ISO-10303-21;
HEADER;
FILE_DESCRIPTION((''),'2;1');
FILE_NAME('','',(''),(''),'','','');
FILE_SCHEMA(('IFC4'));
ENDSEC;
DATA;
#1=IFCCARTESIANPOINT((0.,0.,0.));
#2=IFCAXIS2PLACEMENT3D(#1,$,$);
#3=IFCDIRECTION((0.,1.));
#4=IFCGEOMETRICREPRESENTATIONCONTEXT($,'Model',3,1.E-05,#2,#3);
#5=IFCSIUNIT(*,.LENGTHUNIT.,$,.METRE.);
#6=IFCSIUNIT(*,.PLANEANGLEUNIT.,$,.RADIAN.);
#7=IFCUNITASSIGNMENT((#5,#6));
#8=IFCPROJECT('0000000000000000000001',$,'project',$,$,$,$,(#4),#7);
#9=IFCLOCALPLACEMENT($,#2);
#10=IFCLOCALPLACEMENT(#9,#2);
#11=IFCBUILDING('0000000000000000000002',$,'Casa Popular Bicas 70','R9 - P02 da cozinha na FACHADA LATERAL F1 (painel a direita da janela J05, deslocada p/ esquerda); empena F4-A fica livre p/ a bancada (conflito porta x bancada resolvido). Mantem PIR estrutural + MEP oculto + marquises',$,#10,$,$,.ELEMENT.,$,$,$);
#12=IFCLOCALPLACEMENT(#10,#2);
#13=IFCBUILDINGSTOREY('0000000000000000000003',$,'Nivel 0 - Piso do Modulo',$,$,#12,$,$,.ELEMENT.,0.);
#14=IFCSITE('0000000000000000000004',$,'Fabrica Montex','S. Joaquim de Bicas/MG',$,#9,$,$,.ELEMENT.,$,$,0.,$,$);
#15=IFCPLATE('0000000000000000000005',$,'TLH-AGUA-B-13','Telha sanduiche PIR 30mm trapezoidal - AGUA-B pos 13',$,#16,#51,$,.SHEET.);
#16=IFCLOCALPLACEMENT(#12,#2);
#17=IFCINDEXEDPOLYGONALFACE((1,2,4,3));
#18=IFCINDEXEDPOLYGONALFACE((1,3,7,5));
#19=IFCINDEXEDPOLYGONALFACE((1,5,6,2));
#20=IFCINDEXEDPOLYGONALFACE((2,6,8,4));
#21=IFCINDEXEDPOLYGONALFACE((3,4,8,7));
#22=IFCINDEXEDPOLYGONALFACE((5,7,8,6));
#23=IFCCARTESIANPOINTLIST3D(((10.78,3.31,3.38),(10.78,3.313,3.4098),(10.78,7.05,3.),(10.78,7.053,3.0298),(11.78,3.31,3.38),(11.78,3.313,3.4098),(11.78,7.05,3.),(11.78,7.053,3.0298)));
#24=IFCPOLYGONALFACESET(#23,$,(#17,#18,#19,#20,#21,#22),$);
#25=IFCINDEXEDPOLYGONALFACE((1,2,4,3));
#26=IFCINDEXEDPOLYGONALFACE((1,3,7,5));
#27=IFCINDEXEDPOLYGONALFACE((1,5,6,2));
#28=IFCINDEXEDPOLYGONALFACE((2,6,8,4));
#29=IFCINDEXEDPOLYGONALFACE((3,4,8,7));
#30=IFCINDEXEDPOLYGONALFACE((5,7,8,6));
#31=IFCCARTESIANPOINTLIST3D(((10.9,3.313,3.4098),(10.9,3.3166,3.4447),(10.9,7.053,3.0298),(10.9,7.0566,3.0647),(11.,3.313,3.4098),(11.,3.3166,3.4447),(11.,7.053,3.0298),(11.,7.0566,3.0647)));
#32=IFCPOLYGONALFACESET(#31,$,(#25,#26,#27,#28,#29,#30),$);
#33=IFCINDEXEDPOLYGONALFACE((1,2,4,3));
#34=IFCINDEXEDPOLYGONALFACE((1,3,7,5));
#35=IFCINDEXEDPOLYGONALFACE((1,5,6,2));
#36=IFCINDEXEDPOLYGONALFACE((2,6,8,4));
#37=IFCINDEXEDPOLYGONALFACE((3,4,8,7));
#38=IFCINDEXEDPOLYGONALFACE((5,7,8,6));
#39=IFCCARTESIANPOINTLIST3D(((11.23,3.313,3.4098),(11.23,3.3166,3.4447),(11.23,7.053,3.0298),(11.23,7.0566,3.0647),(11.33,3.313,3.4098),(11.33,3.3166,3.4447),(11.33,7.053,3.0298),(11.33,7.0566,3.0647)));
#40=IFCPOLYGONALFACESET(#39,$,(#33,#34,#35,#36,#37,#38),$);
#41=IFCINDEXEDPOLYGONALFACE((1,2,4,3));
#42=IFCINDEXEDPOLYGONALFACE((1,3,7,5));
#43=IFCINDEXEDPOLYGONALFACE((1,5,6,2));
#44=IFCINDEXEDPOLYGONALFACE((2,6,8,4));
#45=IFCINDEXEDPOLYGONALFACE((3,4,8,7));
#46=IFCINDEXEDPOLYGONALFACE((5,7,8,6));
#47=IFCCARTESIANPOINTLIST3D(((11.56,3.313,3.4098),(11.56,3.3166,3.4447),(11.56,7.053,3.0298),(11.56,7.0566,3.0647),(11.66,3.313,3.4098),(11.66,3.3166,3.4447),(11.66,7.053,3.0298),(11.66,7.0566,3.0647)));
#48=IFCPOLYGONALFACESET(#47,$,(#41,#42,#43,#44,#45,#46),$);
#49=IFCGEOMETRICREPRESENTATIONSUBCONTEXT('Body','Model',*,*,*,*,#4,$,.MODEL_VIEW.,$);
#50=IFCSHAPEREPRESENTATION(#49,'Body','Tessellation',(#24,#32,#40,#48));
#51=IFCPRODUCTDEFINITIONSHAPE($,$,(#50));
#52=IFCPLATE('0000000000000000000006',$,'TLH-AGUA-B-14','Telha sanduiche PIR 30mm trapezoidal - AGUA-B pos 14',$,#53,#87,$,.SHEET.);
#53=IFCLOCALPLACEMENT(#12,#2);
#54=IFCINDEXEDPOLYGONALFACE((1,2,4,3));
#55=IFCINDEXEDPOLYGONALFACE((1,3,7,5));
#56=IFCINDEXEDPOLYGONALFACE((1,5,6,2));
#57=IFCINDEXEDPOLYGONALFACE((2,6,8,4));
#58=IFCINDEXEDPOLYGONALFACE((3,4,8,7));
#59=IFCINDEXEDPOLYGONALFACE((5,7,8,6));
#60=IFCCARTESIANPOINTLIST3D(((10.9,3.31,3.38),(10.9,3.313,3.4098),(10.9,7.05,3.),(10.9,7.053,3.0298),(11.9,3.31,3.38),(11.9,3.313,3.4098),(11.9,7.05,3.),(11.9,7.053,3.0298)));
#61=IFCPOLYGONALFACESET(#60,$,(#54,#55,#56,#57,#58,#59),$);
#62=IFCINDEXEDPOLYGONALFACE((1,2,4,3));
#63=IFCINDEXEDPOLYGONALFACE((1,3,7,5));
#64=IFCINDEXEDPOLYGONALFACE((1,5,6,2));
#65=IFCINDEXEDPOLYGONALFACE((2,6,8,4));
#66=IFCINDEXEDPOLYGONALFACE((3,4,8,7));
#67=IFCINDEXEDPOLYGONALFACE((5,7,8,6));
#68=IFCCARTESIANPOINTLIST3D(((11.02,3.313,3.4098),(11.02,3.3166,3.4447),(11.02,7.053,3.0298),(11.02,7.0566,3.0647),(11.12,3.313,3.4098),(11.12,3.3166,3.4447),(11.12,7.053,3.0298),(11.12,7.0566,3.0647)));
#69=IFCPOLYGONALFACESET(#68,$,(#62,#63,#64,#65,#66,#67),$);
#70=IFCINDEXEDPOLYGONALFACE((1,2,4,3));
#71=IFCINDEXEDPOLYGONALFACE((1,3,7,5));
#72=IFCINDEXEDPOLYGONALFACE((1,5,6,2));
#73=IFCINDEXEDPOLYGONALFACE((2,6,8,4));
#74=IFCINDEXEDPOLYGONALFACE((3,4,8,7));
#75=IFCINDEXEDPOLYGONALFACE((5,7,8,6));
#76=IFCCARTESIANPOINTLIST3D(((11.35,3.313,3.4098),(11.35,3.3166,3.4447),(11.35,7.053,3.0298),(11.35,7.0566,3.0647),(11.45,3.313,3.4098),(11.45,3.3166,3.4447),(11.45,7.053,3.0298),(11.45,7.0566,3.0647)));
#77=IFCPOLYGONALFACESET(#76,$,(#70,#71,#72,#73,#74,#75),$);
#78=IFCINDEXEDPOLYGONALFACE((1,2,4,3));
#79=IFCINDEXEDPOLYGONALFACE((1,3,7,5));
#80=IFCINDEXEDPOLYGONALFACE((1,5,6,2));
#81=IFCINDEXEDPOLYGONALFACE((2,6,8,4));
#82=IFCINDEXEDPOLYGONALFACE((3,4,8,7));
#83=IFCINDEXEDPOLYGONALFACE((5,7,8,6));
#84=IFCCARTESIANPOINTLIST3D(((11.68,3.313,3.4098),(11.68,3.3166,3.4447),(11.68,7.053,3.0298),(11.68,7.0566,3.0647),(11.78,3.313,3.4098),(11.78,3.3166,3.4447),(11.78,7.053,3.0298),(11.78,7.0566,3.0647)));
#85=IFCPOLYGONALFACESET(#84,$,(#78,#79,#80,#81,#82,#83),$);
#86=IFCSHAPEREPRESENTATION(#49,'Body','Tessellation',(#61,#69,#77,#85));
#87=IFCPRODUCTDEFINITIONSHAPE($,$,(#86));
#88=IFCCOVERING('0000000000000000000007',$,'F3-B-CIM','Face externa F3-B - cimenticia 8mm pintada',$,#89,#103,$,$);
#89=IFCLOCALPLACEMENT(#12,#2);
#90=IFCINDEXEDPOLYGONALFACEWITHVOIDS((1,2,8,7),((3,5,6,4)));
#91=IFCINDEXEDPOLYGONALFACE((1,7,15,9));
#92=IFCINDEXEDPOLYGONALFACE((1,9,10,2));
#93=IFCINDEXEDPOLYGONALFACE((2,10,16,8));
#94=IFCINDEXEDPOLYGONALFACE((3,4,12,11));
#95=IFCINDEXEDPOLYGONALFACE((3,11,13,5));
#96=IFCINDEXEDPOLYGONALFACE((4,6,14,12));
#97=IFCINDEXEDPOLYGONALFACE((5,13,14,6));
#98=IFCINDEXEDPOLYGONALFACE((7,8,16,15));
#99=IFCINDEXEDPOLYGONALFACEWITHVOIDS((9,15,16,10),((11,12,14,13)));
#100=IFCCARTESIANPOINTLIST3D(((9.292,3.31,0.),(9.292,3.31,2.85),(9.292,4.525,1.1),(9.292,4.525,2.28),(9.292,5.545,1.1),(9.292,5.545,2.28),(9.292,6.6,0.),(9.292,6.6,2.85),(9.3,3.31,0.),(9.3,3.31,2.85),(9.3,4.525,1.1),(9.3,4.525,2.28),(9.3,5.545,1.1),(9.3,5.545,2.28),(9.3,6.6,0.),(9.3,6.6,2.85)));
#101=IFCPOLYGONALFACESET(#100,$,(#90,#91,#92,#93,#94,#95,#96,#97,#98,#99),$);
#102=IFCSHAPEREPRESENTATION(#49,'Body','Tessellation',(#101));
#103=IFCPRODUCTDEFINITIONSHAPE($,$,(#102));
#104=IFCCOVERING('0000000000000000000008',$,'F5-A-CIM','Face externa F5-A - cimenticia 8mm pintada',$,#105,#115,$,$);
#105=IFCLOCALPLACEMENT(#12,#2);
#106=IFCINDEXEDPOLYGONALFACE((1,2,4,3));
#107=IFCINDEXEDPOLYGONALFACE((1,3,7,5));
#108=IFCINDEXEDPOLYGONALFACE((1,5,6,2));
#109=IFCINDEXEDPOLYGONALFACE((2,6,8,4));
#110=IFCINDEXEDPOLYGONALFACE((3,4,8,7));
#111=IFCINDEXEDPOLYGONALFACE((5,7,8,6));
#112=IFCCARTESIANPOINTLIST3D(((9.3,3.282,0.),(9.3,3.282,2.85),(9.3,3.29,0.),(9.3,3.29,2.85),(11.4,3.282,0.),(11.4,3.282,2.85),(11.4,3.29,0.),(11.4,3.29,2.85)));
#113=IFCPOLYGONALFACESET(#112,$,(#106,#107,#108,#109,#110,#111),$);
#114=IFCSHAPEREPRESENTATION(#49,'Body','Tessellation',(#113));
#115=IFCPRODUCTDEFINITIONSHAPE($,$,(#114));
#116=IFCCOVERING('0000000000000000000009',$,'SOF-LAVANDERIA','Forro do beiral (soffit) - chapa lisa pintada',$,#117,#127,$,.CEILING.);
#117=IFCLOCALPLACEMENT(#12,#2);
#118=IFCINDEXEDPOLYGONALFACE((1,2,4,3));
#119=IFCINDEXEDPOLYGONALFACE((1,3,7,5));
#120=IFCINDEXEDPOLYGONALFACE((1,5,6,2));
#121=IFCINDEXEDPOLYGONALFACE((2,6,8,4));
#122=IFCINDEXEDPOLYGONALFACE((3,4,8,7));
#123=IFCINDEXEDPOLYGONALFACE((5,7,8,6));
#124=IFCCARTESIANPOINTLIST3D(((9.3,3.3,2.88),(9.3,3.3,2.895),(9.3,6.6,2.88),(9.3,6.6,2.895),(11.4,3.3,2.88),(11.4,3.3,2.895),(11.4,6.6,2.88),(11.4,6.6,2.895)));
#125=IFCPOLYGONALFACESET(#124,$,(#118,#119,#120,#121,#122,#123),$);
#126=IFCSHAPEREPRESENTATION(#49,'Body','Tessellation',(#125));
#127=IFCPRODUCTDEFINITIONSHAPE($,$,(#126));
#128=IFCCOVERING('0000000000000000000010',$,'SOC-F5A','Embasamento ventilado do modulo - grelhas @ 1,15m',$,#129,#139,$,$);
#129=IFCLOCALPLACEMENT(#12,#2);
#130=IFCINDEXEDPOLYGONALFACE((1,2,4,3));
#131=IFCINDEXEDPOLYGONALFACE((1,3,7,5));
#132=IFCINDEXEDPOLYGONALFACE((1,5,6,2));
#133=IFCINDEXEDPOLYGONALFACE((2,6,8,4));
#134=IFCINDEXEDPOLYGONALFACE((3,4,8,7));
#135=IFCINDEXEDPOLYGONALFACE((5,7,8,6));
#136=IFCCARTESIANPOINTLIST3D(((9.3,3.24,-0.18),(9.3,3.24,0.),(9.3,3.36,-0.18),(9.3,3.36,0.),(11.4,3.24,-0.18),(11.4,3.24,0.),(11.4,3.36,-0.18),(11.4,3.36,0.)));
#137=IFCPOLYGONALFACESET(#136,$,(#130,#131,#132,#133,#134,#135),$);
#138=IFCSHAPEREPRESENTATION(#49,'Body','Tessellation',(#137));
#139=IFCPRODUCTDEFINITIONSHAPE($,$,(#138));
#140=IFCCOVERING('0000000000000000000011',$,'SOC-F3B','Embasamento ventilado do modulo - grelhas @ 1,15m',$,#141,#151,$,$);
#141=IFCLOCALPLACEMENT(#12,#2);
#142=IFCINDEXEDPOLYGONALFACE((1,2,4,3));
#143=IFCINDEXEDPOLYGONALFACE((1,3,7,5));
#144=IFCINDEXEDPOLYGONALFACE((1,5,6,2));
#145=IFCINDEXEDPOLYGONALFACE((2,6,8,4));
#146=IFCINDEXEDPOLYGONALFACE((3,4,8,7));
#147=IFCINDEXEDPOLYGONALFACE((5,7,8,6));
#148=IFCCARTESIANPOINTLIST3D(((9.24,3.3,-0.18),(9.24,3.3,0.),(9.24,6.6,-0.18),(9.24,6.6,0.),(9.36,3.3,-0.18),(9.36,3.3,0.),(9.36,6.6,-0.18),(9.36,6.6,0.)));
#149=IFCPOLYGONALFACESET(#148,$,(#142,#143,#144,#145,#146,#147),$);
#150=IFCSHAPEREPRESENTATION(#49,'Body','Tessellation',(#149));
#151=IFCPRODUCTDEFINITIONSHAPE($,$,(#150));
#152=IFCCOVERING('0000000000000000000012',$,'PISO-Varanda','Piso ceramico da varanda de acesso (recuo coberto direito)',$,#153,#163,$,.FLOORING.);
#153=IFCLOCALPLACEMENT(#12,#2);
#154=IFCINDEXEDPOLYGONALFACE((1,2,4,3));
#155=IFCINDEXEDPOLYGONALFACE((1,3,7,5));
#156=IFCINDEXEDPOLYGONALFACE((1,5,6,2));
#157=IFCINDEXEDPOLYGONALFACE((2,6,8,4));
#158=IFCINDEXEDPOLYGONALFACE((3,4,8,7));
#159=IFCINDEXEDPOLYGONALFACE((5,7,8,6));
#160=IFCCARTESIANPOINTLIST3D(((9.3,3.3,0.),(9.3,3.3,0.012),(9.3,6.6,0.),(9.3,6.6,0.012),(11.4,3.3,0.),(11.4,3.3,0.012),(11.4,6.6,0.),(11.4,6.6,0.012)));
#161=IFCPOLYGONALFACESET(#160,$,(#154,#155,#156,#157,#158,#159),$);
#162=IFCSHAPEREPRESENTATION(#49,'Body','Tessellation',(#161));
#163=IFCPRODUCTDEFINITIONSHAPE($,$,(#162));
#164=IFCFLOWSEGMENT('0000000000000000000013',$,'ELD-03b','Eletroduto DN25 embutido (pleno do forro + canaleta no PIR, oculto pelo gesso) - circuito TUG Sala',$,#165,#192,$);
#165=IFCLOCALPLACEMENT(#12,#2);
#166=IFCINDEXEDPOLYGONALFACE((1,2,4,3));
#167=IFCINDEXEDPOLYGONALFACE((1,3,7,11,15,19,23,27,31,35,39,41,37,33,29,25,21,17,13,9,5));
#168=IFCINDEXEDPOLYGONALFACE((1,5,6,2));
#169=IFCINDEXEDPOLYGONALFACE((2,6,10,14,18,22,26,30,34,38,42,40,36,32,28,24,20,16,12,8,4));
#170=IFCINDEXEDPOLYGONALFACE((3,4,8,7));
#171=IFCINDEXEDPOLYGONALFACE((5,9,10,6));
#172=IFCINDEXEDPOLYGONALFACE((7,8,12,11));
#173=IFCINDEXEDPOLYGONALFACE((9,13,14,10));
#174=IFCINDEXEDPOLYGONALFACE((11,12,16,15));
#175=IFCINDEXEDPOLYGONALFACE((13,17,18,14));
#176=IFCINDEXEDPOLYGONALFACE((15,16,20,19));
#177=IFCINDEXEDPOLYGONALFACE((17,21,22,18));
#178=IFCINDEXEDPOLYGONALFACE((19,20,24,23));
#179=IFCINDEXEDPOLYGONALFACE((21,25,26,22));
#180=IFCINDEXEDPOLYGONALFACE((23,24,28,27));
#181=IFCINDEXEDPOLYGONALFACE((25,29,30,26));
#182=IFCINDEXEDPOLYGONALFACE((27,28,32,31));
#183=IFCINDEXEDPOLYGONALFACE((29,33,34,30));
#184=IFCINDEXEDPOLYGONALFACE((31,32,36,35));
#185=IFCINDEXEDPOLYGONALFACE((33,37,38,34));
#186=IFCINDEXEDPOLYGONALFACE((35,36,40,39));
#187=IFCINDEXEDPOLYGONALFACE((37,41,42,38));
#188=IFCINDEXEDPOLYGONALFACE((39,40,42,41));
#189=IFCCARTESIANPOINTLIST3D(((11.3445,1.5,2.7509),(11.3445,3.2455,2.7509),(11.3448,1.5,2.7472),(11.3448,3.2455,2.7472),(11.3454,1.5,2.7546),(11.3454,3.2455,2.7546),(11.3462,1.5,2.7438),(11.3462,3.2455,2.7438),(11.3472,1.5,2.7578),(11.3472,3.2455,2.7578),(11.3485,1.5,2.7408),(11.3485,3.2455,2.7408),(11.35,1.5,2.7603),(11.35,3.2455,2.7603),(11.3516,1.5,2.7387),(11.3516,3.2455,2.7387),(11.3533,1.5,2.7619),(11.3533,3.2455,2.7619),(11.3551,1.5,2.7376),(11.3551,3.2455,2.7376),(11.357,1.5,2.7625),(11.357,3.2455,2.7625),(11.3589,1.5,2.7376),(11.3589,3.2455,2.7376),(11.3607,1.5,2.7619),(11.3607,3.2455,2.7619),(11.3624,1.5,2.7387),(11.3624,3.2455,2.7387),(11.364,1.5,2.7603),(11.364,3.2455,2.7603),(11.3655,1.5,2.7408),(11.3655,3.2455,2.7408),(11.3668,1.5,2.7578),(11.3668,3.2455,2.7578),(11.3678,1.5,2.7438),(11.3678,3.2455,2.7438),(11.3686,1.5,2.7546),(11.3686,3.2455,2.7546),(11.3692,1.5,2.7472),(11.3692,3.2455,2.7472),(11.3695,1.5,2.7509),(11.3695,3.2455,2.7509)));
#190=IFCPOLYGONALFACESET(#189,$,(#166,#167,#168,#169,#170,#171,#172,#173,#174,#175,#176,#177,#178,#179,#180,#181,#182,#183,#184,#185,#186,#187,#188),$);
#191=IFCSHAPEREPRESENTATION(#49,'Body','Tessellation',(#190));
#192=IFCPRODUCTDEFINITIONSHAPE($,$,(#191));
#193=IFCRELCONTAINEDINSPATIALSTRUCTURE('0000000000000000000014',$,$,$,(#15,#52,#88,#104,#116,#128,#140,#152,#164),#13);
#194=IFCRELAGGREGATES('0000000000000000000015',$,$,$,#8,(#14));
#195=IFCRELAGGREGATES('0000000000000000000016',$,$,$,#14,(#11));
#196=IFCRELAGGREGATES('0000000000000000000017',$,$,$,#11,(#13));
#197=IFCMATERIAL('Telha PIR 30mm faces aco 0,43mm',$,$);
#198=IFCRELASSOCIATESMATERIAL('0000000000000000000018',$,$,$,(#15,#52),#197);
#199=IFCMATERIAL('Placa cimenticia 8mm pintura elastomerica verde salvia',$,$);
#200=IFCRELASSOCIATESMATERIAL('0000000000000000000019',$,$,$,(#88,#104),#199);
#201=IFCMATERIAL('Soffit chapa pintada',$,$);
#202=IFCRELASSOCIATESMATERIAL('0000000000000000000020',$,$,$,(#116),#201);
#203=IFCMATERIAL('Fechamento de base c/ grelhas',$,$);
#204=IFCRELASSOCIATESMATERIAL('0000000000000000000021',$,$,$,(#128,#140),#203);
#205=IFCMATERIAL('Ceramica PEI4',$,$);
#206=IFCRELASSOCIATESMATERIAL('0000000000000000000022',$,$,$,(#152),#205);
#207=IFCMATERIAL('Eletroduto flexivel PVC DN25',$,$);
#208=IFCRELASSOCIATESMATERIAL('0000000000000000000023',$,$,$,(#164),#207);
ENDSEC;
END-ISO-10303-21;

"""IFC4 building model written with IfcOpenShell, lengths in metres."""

from ifc_helpers import new_model, si_unit, direction, frame, frame_2d, origin, origin_2d, place, context, subcontext, project, spatial, rectangle, circle, extrude, material, element, save


model = new_model("IFC4")

# Units and contexts
model_context = context("Model", 3, precision=1e-05, world=origin(), true_north=direction((0.0, 1.0)))
body_context = subcontext(model_context, "Body", "Model", "MODEL_VIEW")
ifc_project = project(units=[si_unit("LENGTHUNIT", "METRE"), si_unit("PLANEANGLEUNIT", "RADIAN")], contexts=[model_context])

# Site, building, storey
site_placement = place(None, origin())
site = spatial("IfcSite", under=ifc_project, at=site_placement, Name="Fabrica Montex", Description="S. Joaquim de Bicas/MG", CompositionType="ELEMENT", RefElevation=0.0)
building_placement = place(site_placement, origin())
building = spatial("IfcBuilding", under=site, at=building_placement, Name="Casa Popular Bicas 70", Description="R9 - P02 da cozinha na FACHADA LATERAL F1 (painel a direita da janela J05, deslocada p/ esquerda); empena F4-A fica livre p/ a bancada (conflito porta x bancada resolvido). Mantem PIR estrutural + MEP oculto + marquises", CompositionType="ELEMENT")
storey_placement = place(building_placement, origin())
storey = spatial("IfcBuildingStorey", under=building, at=storey_placement, Name="Nivel 0 - Piso do Modulo", CompositionType="ELEMENT", Elevation=0.0)

# Plates
ifc_material_1 = material(Name="Telha PIR 30mm faces aco 0,43mm")
for number, where, z_axis, x_axis, name, description in (
    (1, (10.78, 3.31, 3.38), (0.0, 0.101084, 0.994878), (1.0, 0.0, 0.0), "TLH-AGUA-B-13", "Telha sanduiche PIR 30mm trapezoidal - AGUA-B pos 13"),
    (2, (10.9, 3.31, 3.38), (0.0, 0.101084, 0.994878), (1.0, 0.0, 0.0), "TLH-AGUA-B-14", "Telha sanduiche PIR 30mm trapezoidal - AGUA-B pos 14"),
):
    element("IfcPlate", number, at=place(storey_placement, frame(where, z_axis=z_axis, x_axis=x_axis)), inside=storey, material=ifc_material_1, Name=name, Description=description, PredefinedType="SHEET", context=body_context, shape_type="SweptSolid", body=[
        extrude(rectangle(XDim=1.0, YDim=3.7593, at=frame_2d((0.5, 1.8796))), origin(), (0.0, 0.0, 1.0), 0.03),
        extrude(rectangle(XDim=0.1, YDim=3.7593, at=frame_2d((0.17, 1.8796))), frame((0.0, 0.0, 0.03)), (0.0, 0.0, 1.0), 0.035),
        extrude(rectangle(XDim=0.1, YDim=3.7593, at=frame_2d((0.5, 1.8796))), frame((0.0, 0.0, 0.03)), (0.0, 0.0, 1.0), 0.035),
        extrude(rectangle(XDim=0.1, YDim=3.7593, at=frame_2d((0.83, 1.8796))), frame((0.0, 0.0, 0.03)), (0.0, 0.0, 1.0), 0.035),
    ])

# Covering, opening
ifc_material_2 = material(Name="Placa cimenticia 8mm pintura elastomerica verde salvia")
covering_1_placement = place(storey_placement, frame((9.296, 3.31, 0.0), x_axis=(0.0, 1.0, 0.0)))
covering_1 = element("IfcCovering", 3, at=covering_1_placement, inside=storey, material=ifc_material_2, Name="F3-B-CIM", Description="Face externa F3-B - cimenticia 8mm pintada", context=body_context, shape_type="SweptSolid", body=[
    extrude(rectangle(XDim=3.29, YDim=0.008, at=frame_2d((1.645, 0.0))), origin(), (0.0, 0.0, 1.0), 2.85),
])
opening_1_placement = place(storey_placement, frame((9.296, 4.535, 1.1), x_axis=(0.0, 1.0, 0.0)))
element("IfcOpeningElement", 4, at=opening_1_placement, cuts=covering_1, PredefinedType="OPENING", context=body_context, shape_type="SweptSolid", body=[
    extrude(rectangle(XDim=1.02, YDim=0.03, at=frame_2d((0.5, 0.0))), origin(), (0.0, 0.0, 1.0), 1.18),
])

# Coverings
covering_2_placement = place(storey_placement, frame((9.3, 3.286, 0.0), x_axis=(1.0, 0.0, 0.0)))
element("IfcCovering", 5, at=covering_2_placement, inside=storey, material=ifc_material_2, Name="F5-A-CIM", Description="Face externa F5-A - cimenticia 8mm pintada", context=body_context, shape_type="SweptSolid", body=[
    extrude(rectangle(XDim=2.1, YDim=0.008, at=frame_2d((1.05, 0.0))), origin(), (0.0, 0.0, 1.0), 2.85),
])
ifc_material_3 = material(Name="Soffit chapa pintada")
covering_3_placement = place(storey_placement, frame((9.3, 3.3, 2.88)))
element("IfcCovering", 6, at=covering_3_placement, inside=storey, material=ifc_material_3, Name="SOF-LAVANDERIA", Description="Forro do beiral (soffit) - chapa lisa pintada", PredefinedType="CEILING", context=body_context, shape_type="SweptSolid", body=[
    extrude(rectangle(XDim=2.1, YDim=3.3, at=frame_2d((1.05, 1.65))), origin(), (0.0, 0.0, 1.0), 0.015),
])
ifc_material_4 = material(Name="Fechamento de base c/ grelhas")
covering_4_placement = place(storey_placement, frame((9.3, 3.3, -0.18), x_axis=(1.0, 0.0, 0.0)))
element("IfcCovering", 7, at=covering_4_placement, inside=storey, material=ifc_material_4, Name="SOC-F5A", Description="Embasamento ventilado do modulo - grelhas @ 1,15m", context=body_context, shape_type="SweptSolid", body=[
    extrude(rectangle(XDim=2.1, YDim=0.12, at=frame_2d((1.05, 0.0))), origin(), (0.0, 0.0, 1.0), 0.18),
])
covering_5_placement = place(storey_placement, frame((9.3, 3.3, -0.18), x_axis=(0.0, 1.0, 0.0)))
element("IfcCovering", 8, at=covering_5_placement, inside=storey, material=ifc_material_4, Name="SOC-F3B", Description="Embasamento ventilado do modulo - grelhas @ 1,15m", context=body_context, shape_type="SweptSolid", body=[
    extrude(rectangle(XDim=3.3, YDim=0.12, at=frame_2d((1.65, 0.0))), origin(), (0.0, 0.0, 1.0), 0.18),
])
ifc_material_5 = material(Name="Ceramica PEI4")
covering_6_placement = place(storey_placement, frame((9.3, 3.3, 0.0)))
element("IfcCovering", 9, at=covering_6_placement, inside=storey, material=ifc_material_5, Name="PISO-Varanda", Description="Piso ceramico da varanda de acesso (recuo coberto direito)", PredefinedType="FLOORING", context=body_context, shape_type="SweptSolid", body=[
    extrude(rectangle(XDim=2.1, YDim=3.3, at=frame_2d((1.05, 1.65))), origin(), (0.0, 0.0, 1.0), 0.012),
])

# Flow segment
ifc_material_6 = material(Name="Eletroduto flexivel PVC DN25")
flow_segment_1_placement = place(storey_placement, frame((11.357, 3.2455, 2.75), z_axis=(0.0, -1.0, 0.0), x_axis=(0.0, 0.0, 1.0)))
element("IfcFlowSegment", 10, at=flow_segment_1_placement, inside=storey, material=ifc_material_6, Name="ELD-03b", Description="Eletroduto DN25 embutido (pleno do forro + canaleta no PIR, oculto pelo gesso) - circuito TUG Sala", context=body_context, shape_type="SweptSolid", body=[
    extrude(circle(Radius=0.0125, at=origin_2d()), origin(), (0.0, 0.0, 1.0), 1.7455),
])

save(model, "model.ifc")
